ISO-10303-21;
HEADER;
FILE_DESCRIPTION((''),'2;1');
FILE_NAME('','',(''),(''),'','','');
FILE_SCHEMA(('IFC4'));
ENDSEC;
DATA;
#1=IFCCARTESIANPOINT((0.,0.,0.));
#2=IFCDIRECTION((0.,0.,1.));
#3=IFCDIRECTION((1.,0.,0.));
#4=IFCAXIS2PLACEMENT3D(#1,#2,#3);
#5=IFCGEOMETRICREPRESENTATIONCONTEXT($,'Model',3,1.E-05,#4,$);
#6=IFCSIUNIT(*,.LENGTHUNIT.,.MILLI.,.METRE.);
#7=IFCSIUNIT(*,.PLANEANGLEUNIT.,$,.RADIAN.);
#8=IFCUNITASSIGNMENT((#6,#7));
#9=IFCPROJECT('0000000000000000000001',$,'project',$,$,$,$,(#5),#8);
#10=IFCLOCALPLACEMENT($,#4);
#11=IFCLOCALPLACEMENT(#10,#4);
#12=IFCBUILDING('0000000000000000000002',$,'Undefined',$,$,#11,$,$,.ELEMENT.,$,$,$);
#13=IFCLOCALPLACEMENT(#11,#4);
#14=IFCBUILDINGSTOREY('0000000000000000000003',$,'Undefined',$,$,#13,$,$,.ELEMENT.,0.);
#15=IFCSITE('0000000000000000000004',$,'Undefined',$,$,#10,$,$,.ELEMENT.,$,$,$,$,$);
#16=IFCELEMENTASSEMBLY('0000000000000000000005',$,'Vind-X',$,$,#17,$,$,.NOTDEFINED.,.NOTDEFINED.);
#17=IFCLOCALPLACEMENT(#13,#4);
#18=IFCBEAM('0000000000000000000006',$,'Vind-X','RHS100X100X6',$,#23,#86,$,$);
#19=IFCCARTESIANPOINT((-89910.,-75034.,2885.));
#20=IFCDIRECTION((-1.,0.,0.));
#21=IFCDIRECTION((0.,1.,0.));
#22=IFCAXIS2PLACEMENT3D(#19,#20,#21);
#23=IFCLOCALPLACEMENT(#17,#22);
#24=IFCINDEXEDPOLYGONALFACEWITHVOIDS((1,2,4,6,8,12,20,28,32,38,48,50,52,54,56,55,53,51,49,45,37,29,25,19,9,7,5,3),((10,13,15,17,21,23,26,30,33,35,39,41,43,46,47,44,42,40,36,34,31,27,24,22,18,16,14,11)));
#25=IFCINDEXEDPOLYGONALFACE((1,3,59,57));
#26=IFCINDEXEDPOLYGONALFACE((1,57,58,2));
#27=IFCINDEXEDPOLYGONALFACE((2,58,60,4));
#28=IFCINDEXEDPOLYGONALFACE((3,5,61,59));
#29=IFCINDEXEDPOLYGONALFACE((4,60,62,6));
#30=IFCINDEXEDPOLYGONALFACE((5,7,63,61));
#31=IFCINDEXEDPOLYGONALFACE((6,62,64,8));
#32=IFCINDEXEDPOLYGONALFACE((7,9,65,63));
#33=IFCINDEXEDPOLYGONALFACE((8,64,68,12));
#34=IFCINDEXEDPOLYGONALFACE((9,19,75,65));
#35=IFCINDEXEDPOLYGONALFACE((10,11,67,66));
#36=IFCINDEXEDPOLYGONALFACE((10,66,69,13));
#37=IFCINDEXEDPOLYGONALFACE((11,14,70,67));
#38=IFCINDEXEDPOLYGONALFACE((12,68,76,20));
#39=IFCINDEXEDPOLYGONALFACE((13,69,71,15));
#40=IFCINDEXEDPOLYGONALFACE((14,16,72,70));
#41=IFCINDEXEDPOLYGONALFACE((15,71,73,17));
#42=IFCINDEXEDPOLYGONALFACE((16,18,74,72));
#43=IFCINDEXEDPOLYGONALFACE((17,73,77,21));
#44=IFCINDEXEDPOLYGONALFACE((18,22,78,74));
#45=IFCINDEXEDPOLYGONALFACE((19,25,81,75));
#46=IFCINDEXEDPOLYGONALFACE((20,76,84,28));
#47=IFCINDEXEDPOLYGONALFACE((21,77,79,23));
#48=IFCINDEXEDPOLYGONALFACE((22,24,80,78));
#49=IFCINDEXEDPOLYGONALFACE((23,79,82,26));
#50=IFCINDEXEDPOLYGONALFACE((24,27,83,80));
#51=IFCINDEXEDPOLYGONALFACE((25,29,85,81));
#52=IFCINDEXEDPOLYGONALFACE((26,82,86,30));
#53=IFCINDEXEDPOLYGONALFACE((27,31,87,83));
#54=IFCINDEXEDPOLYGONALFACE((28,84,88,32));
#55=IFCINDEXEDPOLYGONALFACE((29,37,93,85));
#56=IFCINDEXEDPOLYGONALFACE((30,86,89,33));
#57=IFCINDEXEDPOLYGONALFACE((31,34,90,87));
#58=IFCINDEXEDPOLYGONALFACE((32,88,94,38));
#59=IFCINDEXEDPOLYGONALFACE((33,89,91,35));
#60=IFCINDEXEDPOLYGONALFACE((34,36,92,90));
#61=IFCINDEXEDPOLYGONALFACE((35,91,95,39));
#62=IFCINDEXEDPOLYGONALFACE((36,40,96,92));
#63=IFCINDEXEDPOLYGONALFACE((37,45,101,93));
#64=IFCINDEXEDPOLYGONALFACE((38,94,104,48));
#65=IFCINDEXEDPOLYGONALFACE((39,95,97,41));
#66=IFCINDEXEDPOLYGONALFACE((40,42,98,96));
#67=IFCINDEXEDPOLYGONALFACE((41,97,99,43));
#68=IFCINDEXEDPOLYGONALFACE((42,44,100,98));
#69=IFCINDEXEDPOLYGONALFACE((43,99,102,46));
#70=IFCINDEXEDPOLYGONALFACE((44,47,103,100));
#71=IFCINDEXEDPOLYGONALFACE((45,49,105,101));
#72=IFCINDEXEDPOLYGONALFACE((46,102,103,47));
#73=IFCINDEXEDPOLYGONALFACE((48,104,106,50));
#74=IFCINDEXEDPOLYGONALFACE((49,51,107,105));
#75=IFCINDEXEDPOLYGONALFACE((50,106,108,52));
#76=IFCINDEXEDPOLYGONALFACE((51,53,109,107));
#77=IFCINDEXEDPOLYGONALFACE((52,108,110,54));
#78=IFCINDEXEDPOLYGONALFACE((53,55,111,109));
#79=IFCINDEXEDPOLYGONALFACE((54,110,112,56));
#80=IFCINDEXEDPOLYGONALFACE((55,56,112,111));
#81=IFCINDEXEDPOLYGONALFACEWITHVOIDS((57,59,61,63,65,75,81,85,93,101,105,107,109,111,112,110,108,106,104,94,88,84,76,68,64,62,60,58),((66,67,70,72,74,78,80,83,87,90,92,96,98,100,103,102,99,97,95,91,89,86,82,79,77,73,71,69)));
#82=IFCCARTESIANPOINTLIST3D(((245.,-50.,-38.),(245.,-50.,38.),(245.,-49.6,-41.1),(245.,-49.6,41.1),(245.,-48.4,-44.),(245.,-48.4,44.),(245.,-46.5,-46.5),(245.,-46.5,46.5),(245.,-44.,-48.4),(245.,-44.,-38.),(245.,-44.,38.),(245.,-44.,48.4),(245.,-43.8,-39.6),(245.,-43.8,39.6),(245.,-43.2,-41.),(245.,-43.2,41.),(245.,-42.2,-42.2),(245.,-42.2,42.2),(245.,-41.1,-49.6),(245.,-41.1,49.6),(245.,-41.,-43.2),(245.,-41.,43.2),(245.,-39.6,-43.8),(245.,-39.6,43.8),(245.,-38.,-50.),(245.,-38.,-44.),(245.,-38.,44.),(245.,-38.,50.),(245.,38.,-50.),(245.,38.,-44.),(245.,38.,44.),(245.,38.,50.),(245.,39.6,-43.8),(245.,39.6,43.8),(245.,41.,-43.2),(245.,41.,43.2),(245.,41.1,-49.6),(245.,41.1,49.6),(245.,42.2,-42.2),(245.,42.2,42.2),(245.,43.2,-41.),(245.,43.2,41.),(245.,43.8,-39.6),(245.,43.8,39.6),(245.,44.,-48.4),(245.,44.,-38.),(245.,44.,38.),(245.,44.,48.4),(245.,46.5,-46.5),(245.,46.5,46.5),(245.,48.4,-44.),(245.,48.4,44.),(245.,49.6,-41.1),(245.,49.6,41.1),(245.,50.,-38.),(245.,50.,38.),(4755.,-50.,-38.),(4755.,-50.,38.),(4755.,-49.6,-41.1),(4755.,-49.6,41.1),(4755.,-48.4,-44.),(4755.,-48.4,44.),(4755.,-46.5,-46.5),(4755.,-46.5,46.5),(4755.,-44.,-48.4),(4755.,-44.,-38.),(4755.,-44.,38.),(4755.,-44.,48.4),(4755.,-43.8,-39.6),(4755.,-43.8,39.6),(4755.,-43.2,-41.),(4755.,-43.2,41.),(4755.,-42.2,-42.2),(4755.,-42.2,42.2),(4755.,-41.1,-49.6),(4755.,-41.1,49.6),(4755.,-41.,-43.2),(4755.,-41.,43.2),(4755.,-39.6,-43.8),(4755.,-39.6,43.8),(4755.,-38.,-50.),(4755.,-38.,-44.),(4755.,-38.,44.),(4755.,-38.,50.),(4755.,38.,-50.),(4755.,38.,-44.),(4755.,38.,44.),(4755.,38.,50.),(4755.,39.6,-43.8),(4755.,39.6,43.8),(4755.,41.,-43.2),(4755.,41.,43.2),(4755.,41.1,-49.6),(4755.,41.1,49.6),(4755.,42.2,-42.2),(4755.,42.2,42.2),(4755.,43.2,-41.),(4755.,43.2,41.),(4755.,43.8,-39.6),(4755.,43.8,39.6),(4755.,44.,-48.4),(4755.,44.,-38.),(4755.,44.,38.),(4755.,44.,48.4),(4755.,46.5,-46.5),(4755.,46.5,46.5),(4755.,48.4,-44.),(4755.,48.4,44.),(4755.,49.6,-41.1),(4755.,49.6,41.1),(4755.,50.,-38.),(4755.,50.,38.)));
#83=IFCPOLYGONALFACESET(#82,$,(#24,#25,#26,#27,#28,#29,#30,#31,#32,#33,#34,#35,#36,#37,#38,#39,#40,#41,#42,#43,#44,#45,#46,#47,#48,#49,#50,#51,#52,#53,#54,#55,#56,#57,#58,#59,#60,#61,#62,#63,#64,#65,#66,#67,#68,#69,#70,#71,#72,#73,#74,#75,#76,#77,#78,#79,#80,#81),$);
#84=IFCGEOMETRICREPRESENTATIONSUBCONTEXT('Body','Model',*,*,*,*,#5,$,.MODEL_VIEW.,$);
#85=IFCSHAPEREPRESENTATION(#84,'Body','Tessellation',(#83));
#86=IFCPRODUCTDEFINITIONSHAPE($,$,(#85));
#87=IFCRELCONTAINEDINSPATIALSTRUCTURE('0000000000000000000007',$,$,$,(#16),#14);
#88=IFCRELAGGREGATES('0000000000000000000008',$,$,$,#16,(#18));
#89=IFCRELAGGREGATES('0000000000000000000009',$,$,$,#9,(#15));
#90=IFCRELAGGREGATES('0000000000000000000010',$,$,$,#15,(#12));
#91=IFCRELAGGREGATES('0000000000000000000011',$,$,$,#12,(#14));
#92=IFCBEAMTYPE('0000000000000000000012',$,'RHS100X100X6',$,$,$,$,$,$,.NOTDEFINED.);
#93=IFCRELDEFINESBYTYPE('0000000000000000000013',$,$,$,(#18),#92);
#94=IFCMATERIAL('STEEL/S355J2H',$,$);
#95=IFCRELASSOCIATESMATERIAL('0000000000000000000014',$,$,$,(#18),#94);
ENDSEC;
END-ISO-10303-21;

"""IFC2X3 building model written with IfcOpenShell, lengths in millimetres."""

from ifc_helpers import new_model, si_unit, frame, origin_with_axes, origin_2d_with_axis, place, context, subcontext, project, spatial, hollow_rectangle, extrude, clip, halfspace, material, type_object, element, aggregate, save


model = new_model("IFC2X3")

# Units and contexts
model_context = context("Model", 3, precision=1e-05, world=origin_with_axes())
body_context = subcontext(model_context, "Body", "Model", "MODEL_VIEW")
ifc_project = project(units=[si_unit("LENGTHUNIT", "METRE", prefix="MILLI"), si_unit("PLANEANGLEUNIT", "RADIAN")], contexts=[model_context])

# Site, building, storey
site_placement = place(None, origin_with_axes())
site = spatial("IfcSite", under=ifc_project, at=site_placement, Name="Undefined", CompositionType="ELEMENT")
building_placement = place(site_placement, origin_with_axes())
building = spatial("IfcBuilding", under=site, at=building_placement, Name="Undefined", CompositionType="ELEMENT")
storey_placement = place(building_placement, origin_with_axes())
storey = spatial("IfcBuildingStorey", under=building, at=storey_placement, Name="Undefined", CompositionType="ELEMENT", Elevation=0.0)

# Shared definitions
ifc_material_1 = material(Name="STEEL/S355J2H")

# Element assembly, beam
assembly_1_placement = place(storey_placement, origin_with_axes())
assembly_1 = element("IfcElementAssembly", 1, at=assembly_1_placement, inside=storey, Name="Vind-X", AssemblyPlace="NOTDEFINED", PredefinedType="NOTDEFINED")
beam_type_1 = type_object("IfcBeamType", Name="RHS100X100X6", PredefinedType="NOTDEFINED")
beam_1_placement = place(assembly_1_placement, frame((-89910.0, -75034.0, 2885.0), z_axis=(-1.0, 0.0, 0.0), x_axis=(0.0, 1.0, 0.0)))
beam_1 = element("IfcBeam", 2, at=beam_1_placement, type_object=beam_type_1, material=ifc_material_1, Name="Vind-X", Description="RHS100X100X6", context=body_context, shape_type="Clipping", body=[
    clip(clip(extrude(hollow_rectangle(XDim=100.0, YDim=100.0, WallThickness=6.0, InnerFilletRadius=6.0, OuterFilletRadius=12.0, at=origin_2d_with_axis()), frame((5000.0, 0.0, 0.0), z_axis=(-1.0, 0.0, 0.0), x_axis=(0.0, -1.0, 0.0)), (0.0, 0.0, 1.0), 5000.0), halfspace(frame((4755.0, 22.5, 0.0), z_axis=(-1.0, 0.0, 0.0), x_axis=(0.0, 0.0, 1.0)), True)), halfspace(frame((245.0, 22.5, 0.0), z_axis=(1.0, 0.0, 0.0), x_axis=(0.0, 0.0, -1.0)), True)),
])

aggregate(assembly_1, [beam_1])

save(model, "model.ifc")
